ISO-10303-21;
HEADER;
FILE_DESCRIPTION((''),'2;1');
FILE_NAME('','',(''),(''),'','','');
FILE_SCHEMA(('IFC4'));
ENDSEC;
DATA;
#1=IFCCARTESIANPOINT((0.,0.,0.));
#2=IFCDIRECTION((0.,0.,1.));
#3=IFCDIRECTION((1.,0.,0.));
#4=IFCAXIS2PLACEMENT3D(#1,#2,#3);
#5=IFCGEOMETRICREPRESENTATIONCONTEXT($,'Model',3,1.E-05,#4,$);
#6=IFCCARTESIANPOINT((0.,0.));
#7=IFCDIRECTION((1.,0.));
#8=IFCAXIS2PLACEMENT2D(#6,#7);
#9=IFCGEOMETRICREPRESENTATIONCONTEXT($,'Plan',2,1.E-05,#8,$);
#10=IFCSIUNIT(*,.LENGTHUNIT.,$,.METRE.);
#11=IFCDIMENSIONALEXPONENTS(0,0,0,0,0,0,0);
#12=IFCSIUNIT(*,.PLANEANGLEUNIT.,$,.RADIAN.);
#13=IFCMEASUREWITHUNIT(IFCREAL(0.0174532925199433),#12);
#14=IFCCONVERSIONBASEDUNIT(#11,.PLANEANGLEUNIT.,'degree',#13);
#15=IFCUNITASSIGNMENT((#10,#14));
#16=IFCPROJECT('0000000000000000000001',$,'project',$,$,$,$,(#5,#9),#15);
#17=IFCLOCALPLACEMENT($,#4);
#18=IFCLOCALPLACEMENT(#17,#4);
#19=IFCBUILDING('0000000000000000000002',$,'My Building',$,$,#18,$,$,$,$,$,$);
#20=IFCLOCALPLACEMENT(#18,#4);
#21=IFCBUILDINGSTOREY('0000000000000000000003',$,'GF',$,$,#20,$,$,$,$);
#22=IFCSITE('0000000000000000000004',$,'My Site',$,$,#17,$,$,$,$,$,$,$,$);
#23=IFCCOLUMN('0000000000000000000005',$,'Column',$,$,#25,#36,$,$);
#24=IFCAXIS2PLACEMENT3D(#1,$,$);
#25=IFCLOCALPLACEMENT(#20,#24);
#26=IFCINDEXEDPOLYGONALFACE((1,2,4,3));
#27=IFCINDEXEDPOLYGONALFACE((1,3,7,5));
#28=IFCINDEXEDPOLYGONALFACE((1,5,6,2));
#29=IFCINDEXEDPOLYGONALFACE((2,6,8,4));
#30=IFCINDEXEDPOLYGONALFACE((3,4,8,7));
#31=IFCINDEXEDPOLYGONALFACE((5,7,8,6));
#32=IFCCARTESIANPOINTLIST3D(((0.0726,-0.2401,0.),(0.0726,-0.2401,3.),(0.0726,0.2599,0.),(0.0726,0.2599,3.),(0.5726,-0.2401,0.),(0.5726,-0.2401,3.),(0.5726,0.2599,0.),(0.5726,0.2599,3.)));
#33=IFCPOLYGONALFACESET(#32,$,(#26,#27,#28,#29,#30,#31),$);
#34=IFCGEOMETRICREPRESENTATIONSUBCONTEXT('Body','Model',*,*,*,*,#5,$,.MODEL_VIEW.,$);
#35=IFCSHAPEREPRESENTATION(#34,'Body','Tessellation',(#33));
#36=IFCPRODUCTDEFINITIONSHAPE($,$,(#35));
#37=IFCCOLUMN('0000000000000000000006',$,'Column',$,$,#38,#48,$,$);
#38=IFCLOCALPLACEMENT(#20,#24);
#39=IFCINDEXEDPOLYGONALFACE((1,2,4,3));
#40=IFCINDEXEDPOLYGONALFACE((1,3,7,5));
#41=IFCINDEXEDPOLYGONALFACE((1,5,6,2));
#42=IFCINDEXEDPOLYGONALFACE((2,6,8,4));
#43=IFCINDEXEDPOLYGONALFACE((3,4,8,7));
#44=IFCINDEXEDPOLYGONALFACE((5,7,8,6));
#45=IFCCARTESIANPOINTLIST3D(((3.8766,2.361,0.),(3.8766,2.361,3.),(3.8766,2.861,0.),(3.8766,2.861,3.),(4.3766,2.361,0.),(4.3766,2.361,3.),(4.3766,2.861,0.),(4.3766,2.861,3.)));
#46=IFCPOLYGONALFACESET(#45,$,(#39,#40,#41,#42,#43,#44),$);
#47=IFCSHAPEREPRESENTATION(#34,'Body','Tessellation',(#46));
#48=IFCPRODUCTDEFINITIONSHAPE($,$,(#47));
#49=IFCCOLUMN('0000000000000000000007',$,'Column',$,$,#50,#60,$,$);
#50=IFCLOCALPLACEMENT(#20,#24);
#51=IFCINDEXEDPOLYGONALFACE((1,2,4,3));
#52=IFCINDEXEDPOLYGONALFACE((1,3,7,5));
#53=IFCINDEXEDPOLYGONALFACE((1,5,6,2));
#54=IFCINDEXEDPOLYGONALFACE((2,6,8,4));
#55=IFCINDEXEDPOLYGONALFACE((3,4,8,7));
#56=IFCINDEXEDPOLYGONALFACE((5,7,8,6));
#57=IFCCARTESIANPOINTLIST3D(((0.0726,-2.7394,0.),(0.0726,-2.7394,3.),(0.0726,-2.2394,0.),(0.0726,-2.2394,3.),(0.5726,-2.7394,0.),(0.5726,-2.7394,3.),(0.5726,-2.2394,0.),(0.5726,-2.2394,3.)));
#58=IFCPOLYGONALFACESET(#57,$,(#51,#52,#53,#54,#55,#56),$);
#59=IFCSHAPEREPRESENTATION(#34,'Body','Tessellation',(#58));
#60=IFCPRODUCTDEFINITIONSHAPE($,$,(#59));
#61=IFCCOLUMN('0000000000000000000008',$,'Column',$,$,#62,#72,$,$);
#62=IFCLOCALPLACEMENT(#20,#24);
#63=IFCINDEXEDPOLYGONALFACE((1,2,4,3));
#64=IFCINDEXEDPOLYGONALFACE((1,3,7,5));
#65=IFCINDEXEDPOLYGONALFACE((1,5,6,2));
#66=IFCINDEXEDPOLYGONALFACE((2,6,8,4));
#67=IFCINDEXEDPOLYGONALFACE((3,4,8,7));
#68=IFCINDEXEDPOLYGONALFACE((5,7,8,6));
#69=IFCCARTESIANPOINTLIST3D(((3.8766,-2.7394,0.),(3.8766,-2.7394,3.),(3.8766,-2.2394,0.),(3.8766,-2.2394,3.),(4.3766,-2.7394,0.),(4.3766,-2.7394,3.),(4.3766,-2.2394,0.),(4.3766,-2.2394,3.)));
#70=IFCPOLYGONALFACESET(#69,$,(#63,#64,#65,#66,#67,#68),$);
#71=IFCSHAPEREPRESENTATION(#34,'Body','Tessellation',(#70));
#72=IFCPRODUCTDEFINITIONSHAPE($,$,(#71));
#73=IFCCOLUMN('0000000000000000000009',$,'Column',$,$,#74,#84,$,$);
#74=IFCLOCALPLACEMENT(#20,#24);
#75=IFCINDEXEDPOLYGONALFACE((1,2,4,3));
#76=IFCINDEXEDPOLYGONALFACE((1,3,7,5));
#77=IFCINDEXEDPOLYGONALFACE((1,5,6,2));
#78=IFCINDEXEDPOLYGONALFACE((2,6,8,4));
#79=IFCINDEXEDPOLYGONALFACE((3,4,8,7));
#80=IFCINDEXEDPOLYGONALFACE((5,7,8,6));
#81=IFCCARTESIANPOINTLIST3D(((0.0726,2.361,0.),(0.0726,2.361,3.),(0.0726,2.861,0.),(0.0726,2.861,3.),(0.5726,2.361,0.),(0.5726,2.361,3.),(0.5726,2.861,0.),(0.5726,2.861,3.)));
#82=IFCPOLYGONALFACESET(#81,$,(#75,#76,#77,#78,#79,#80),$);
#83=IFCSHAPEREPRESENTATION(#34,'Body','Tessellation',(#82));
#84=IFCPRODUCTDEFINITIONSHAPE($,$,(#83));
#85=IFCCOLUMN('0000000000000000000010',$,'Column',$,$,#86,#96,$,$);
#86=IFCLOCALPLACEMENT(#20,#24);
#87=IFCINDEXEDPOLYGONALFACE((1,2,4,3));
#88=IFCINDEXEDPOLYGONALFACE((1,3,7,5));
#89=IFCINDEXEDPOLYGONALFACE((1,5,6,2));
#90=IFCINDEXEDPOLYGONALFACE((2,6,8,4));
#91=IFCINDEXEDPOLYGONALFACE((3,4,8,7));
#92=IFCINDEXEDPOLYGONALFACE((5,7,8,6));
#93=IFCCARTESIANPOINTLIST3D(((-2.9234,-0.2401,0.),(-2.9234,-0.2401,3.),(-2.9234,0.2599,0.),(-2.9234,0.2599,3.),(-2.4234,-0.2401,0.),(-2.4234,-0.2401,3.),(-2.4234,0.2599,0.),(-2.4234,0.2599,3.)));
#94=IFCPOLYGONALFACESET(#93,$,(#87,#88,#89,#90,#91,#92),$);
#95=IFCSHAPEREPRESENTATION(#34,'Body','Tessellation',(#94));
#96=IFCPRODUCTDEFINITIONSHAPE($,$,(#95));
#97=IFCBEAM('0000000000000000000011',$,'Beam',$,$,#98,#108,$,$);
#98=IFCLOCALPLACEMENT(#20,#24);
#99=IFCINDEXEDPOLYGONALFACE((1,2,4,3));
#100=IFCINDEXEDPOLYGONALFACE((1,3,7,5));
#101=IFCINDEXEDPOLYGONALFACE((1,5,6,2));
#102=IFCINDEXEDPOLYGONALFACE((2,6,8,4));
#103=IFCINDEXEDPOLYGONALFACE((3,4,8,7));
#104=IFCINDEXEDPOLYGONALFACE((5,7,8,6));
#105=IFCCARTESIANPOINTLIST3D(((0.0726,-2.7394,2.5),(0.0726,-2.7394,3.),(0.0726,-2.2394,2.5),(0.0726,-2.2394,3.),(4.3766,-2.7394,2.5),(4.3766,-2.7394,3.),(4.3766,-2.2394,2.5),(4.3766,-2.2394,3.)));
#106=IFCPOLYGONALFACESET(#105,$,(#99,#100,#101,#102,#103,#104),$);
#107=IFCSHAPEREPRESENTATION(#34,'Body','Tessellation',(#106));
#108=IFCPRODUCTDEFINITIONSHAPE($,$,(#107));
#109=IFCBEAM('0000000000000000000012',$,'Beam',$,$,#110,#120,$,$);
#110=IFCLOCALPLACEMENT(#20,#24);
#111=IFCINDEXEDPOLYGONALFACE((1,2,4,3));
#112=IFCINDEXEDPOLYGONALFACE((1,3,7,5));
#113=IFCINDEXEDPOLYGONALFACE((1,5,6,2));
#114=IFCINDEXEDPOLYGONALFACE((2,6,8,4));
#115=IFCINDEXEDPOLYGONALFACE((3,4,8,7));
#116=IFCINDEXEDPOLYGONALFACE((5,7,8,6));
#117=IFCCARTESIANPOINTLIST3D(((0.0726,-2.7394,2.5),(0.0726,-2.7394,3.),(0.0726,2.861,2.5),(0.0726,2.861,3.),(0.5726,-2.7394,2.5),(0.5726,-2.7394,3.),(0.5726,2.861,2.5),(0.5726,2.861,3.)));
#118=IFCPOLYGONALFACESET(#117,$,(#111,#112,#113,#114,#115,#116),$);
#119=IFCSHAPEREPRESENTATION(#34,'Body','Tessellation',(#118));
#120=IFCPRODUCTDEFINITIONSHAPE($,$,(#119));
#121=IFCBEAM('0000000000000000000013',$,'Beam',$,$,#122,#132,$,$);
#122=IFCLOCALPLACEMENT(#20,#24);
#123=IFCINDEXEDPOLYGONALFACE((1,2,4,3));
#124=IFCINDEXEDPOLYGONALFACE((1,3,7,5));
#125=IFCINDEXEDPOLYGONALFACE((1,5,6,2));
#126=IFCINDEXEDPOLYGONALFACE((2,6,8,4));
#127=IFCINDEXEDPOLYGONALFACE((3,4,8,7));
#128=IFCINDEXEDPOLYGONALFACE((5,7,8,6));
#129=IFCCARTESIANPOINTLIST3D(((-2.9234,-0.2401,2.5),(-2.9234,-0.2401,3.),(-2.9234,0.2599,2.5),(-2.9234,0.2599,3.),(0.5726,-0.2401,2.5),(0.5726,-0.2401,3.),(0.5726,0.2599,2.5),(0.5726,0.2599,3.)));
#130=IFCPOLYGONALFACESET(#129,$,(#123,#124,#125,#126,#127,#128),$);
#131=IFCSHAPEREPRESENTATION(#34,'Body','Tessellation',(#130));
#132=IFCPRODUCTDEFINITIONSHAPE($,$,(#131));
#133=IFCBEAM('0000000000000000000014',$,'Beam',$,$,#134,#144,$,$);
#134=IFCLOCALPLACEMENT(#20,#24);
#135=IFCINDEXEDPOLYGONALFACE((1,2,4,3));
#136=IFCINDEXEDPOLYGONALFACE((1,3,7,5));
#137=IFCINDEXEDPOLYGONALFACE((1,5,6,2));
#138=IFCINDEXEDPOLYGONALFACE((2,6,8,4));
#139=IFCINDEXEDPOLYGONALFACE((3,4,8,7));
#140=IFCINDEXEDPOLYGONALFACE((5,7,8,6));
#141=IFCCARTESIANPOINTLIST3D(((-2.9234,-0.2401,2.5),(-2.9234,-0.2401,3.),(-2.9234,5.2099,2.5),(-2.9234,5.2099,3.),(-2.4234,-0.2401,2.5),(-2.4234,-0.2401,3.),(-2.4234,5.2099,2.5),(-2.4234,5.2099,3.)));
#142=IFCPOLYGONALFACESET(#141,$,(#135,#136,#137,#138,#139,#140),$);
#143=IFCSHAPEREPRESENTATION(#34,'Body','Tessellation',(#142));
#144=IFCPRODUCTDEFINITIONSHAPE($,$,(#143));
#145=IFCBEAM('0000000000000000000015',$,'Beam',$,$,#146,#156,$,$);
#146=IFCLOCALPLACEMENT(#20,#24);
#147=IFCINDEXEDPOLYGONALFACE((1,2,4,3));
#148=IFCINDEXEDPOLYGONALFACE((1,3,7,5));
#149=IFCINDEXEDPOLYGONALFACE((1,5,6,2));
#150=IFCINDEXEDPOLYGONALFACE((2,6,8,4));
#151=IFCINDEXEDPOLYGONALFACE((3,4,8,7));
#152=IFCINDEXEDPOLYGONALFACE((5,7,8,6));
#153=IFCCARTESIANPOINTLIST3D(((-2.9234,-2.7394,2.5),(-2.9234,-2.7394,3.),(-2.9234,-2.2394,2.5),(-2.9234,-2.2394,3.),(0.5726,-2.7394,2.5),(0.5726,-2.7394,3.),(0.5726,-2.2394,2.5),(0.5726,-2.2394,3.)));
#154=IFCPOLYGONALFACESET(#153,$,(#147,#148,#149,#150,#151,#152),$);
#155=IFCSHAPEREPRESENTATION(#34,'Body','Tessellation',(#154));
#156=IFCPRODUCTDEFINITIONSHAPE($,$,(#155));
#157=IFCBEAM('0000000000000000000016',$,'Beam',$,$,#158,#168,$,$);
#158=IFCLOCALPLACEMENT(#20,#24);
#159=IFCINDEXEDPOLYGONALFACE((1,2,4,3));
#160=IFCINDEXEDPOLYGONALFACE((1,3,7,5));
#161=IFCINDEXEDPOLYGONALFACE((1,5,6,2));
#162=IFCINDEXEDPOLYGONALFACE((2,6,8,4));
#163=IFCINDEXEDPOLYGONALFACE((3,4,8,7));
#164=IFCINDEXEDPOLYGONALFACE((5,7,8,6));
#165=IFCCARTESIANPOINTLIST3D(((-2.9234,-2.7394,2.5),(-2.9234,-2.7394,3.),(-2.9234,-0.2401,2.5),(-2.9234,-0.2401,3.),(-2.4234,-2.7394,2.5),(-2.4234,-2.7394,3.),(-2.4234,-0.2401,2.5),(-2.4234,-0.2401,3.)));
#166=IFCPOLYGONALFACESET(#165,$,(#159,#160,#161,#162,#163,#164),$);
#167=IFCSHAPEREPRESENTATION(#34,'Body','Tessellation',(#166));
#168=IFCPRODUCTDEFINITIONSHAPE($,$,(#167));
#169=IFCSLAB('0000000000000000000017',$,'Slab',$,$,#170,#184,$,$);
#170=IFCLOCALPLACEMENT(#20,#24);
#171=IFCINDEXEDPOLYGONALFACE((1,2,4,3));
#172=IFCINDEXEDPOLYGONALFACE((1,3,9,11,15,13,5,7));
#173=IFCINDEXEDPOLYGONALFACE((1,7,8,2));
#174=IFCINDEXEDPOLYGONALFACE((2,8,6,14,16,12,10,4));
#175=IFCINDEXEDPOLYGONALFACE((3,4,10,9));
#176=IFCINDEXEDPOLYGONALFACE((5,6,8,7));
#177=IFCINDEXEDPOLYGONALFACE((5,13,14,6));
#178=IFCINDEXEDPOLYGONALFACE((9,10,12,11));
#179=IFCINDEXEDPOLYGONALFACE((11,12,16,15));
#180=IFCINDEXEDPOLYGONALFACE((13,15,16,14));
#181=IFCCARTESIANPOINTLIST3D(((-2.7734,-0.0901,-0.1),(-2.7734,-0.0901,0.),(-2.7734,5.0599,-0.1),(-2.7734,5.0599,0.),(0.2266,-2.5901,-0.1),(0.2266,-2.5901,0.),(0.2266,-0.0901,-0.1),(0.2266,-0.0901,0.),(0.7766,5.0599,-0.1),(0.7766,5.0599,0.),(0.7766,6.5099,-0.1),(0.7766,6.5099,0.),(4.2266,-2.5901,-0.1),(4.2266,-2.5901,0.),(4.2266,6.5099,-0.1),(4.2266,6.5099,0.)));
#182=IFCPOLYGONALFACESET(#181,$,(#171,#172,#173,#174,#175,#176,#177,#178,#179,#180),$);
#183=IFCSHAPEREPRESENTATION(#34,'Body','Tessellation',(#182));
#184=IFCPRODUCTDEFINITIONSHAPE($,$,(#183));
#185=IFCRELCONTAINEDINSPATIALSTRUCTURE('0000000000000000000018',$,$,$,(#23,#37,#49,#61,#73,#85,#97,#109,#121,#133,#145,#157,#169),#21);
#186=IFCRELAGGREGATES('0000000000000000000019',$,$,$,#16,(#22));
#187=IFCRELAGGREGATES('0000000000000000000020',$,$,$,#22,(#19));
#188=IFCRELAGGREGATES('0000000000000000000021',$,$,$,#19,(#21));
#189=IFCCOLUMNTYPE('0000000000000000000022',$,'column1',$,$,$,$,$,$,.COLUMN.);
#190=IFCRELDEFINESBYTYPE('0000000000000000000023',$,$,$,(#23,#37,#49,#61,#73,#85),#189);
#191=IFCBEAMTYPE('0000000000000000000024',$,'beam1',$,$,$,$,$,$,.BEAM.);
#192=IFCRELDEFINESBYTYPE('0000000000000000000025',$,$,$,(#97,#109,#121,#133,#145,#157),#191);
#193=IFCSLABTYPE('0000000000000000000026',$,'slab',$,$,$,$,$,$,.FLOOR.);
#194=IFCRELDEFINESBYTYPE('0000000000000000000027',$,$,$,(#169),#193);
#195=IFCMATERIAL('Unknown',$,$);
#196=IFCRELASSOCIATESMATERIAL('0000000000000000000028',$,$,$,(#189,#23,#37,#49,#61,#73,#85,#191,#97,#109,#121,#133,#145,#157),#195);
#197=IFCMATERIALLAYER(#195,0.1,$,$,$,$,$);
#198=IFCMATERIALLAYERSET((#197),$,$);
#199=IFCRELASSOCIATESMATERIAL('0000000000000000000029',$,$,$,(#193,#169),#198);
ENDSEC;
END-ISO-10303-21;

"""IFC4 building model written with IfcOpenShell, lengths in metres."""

from ifc_helpers import new_model, entity, si_unit, converted_unit, frame, origin_with_axes, origin_2d_with_axis, place, context, subcontext, project, spatial, indexed_curve, rectangle, outline, extrude, material, layer, layer_set, layer_usage, material_profile, profile_set, profile_usage, type_object, element, save


model = new_model("IFC4")

# Units and contexts
model_context = context("Model", 3, precision=1e-05, world=origin_with_axes())
plan_context = context("Plan", 2, precision=1e-05, world=origin_2d_with_axis())
body_context_1 = subcontext(model_context, "Body", "Model", "MODEL_VIEW")
ifc_project = project(units=[si_unit("LENGTHUNIT", "METRE"), converted_unit("PLANEANGLEUNIT", "degree", entity("IfcReal", 0.0174532925199433), si_unit("PLANEANGLEUNIT", "RADIAN"), dimensions=[0, 0, 0, 0, 0, 0, 0])], contexts=[model_context, plan_context])

# Site, building, storey
site_placement = place(None, origin_with_axes())
site = spatial("IfcSite", under=ifc_project, at=site_placement, Name="My Site")
building_placement = place(site_placement, origin_with_axes())
building = spatial("IfcBuilding", under=site, at=building_placement, Name="My Building")
storey_placement = place(building_placement, origin_with_axes())
storey = spatial("IfcBuildingStorey", under=building, at=storey_placement, Name="GF")

# Columns
ifc_material = material(Name="Unknown")
ifc_material_profile_1 = material_profile(ifc_material, rectangle(XDim=0.5, YDim=0.5))
ifc_profile_set_1 = profile_set([ifc_material_profile_1])
ifc_profile_usage_1 = profile_usage(ifc_profile_set_1, cardinal=5)
column_type = type_object("IfcColumnType", Name="column1", PredefinedType="COLUMN", material=ifc_profile_set_1)
column_1_placement = place(storey_placement, frame((0.3226, 0.0099, 0.0), z_axis=(0.0, 0.0, 1.0), x_axis=(1.0, 0.0, 0.0)))
element("IfcColumn", 1, at=column_1_placement, inside=storey, type_object=column_type, material=ifc_profile_usage_1, Name="Column", context=body_context_1, shape_type="SweptSolid", body=[
    extrude(rectangle(XDim=0.5, YDim=0.5), origin_with_axes(), (0.0, 0.0, 1.0), 3.0),
])
ifc_profile_usage_2 = profile_usage(ifc_profile_set_1, cardinal=5)
column_2_placement = place(storey_placement, frame((4.1266, 2.611, 0.0), z_axis=(0.0, 0.0, 1.0), x_axis=(1.0, 0.0, 0.0)))
element("IfcColumn", 2, at=column_2_placement, inside=storey, type_object=column_type, material=ifc_profile_usage_2, Name="Column", context=body_context_1, shape_type="SweptSolid", body=[
    extrude(rectangle(XDim=0.5, YDim=0.5), origin_with_axes(), (0.0, 0.0, 1.0), 3.0),
])
ifc_profile_usage_3 = profile_usage(ifc_profile_set_1, cardinal=5)
column_3_placement = place(storey_placement, frame((0.3226, -2.4894, 0.0), z_axis=(0.0, 0.0, 1.0), x_axis=(1.0, 0.0, 0.0)))
element("IfcColumn", 3, at=column_3_placement, inside=storey, type_object=column_type, material=ifc_profile_usage_3, Name="Column", context=body_context_1, shape_type="SweptSolid", body=[
    extrude(rectangle(XDim=0.5, YDim=0.5), origin_with_axes(), (0.0, 0.0, 1.0), 3.0),
])
ifc_profile_usage_4 = profile_usage(ifc_profile_set_1, cardinal=5)
column_4_placement = place(storey_placement, frame((4.1266, -2.4894, 0.0), z_axis=(0.0, 0.0, 1.0), x_axis=(1.0, 0.0, 0.0)))
element("IfcColumn", 4, at=column_4_placement, inside=storey, type_object=column_type, material=ifc_profile_usage_4, Name="Column", context=body_context_1, shape_type="SweptSolid", body=[
    extrude(rectangle(XDim=0.5, YDim=0.5), origin_with_axes(), (0.0, 0.0, 1.0), 3.0),
])
ifc_profile_usage_5 = profile_usage(ifc_profile_set_1, cardinal=5)
column_5_placement = place(storey_placement, frame((0.3226, 2.611, 0.0), z_axis=(0.0, 0.0, 1.0), x_axis=(1.0, 0.0, 0.0)))
element("IfcColumn", 5, at=column_5_placement, inside=storey, type_object=column_type, material=ifc_profile_usage_5, Name="Column", context=body_context_1, shape_type="SweptSolid", body=[
    extrude(rectangle(XDim=0.5, YDim=0.5), origin_with_axes(), (0.0, 0.0, 1.0), 3.0),
])
ifc_profile_usage_6 = profile_usage(ifc_profile_set_1, cardinal=5)
column_6_placement = place(storey_placement, frame((-2.6734, 0.0099, 0.0), z_axis=(0.0, 0.0, 1.0), x_axis=(1.0, 0.0, 0.0)))
element("IfcColumn", 6, at=column_6_placement, inside=storey, type_object=column_type, material=ifc_profile_usage_6, Name="Column", context=body_context_1, shape_type="SweptSolid", body=[
    extrude(rectangle(XDim=0.5, YDim=0.5), origin_with_axes(), (0.0, 0.0, 1.0), 3.0),
])

# Beams
ifc_material_profile_2 = material_profile(ifc_material, rectangle(XDim=0.5, YDim=0.5))
ifc_profile_set_2 = profile_set([ifc_material_profile_2])
ifc_profile_usage_7 = profile_usage(ifc_profile_set_2, cardinal=7)
beam_type = type_object("IfcBeamType", Name="beam1", PredefinedType="BEAM", material=ifc_profile_set_2)
beam_1_placement = place(storey_placement, frame((4.3766, -2.7394, 3.0), z_axis=(-1.0, 0.0, 0.0), x_axis=(0.0, -1.0, 0.0)))
element("IfcBeam", 7, at=beam_1_placement, inside=storey, type_object=beam_type, material=ifc_profile_usage_7, Name="Beam", context=body_context_1, shape_type="SweptSolid", body=[
    extrude(rectangle(XDim=0.5, YDim=0.5), frame((-0.25, -0.25, 0.0), z_axis=(0.0, 0.0, 1.0), x_axis=(1.0, 0.0, 0.0)), (0.0, 0.0, 1.0), 4.304),
])
ifc_profile_usage_8 = profile_usage(ifc_profile_set_2, cardinal=7)
beam_2_placement = place(storey_placement, frame((0.0726, -2.7394, 3.0), z_axis=(0.0, 1.0, 0.0), x_axis=(-1.0, 0.0, 0.0)))
element("IfcBeam", 8, at=beam_2_placement, inside=storey, type_object=beam_type, material=ifc_profile_usage_8, Name="Beam", context=body_context_1, shape_type="SweptSolid", body=[
    extrude(rectangle(XDim=0.5, YDim=0.5), frame((-0.25, -0.25, 0.0), z_axis=(0.0, 0.0, 1.0), x_axis=(1.0, 0.0, 0.0)), (0.0, 0.0, 1.0), 5.6004),
])
ifc_profile_usage_9 = profile_usage(ifc_profile_set_2, cardinal=7)
beam_3_placement = place(storey_placement, frame((0.5726, -0.2401, 3.0), z_axis=(-1.0, 0.0, 0.0), x_axis=(0.0, -1.0, 0.0)))
element("IfcBeam", 9, at=beam_3_placement, inside=storey, type_object=beam_type, material=ifc_profile_usage_9, Name="Beam", context=body_context_1, shape_type="SweptSolid", body=[
    extrude(rectangle(XDim=0.5, YDim=0.5), frame((-0.25, -0.25, 0.0), z_axis=(0.0, 0.0, 1.0), x_axis=(1.0, 0.0, 0.0)), (0.0, 0.0, 1.0), 3.496),
])
ifc_profile_usage_10 = profile_usage(ifc_profile_set_2, cardinal=7)
beam_4_placement = place(storey_placement, frame((-2.9234, -0.2401, 3.0), z_axis=(0.0, 1.0, 0.0), x_axis=(-1.0, 0.0, 0.0)))
element("IfcBeam", 10, at=beam_4_placement, inside=storey, type_object=beam_type, material=ifc_profile_usage_10, Name="Beam", context=body_context_1, shape_type="SweptSolid", body=[
    extrude(rectangle(XDim=0.5, YDim=0.5), frame((-0.25, -0.25, 0.0), z_axis=(0.0, 0.0, 1.0), x_axis=(1.0, 0.0, 0.0)), (0.0, 0.0, 1.0), 5.45),
])
ifc_profile_usage_11 = profile_usage(ifc_profile_set_2, cardinal=7)
beam_5_placement = place(storey_placement, frame((0.5726, -2.7394, 3.0), z_axis=(-1.0, 0.0, 0.0), x_axis=(0.0, -1.0, 0.0)))
element("IfcBeam", 11, at=beam_5_placement, inside=storey, type_object=beam_type, material=ifc_profile_usage_11, Name="Beam", context=body_context_1, shape_type="SweptSolid", body=[
    extrude(rectangle(XDim=0.5, YDim=0.5), frame((-0.25, -0.25, 0.0), z_axis=(0.0, 0.0, 1.0), x_axis=(1.0, 0.0, 0.0)), (0.0, 0.0, 1.0), 3.496),
])
ifc_profile_usage_12 = profile_usage(ifc_profile_set_2, cardinal=7)
beam_6_placement = place(storey_placement, frame((-2.4234, -0.2401, 3.0), z_axis=(-0.000003, -1.0, 0.000001), x_axis=(1.0, -0.000003, 0.0)))
element("IfcBeam", 12, at=beam_6_placement, inside=storey, type_object=beam_type, material=ifc_profile_usage_12, Name="Beam", context=body_context_1, shape_type="SweptSolid", body=[
    extrude(rectangle(XDim=0.5, YDim=0.5), frame((-0.25, -0.25, 0.0), z_axis=(0.0, 0.0, 1.0), x_axis=(1.0, 0.0, 0.0)), (0.0, 0.0, 1.0), 2.4993),
])

# Slab
ifc_layer_1 = layer(ifc_material, 0.1)
ifc_layer_set_1 = layer_set([ifc_layer_1])
ifc_layer_usage_1 = layer_usage(ifc_layer_set_1, "AXIS3", "POSITIVE", -0.1)
slab_type_1 = type_object("IfcSlabType", Name="slab", PredefinedType="FLOOR", material=ifc_layer_set_1)
slab_1_placement = place(storey_placement, frame((4.2266, -2.5901, 0.0), z_axis=(0.0, 0.0, 1.0), x_axis=(1.0, 0.0, 0.0)))
element("IfcSlab", 13, at=slab_1_placement, inside=storey, type_object=slab_type_1, material=ifc_layer_usage_1, Name="Slab", context=body_context_1, shape_type="SweptSolid", body=[
    extrude(outline(indexed_curve([(0.0, 0.0), (0.0, 9.1), (-3.45, 9.1), (-3.45, 7.65), (-7.0, 7.65), (-7.0, 2.5), (-4.0, 2.5), (-4.0, 0.0), (0.0, 0.0)])), frame((0.0, 0.0, -0.1), z_axis=(0.0, 0.0, 1.0), x_axis=(1.0, 0.0, 0.0)), (0.0, 0.0, 1.0), 0.1),
])

save(model, "model.ifc")
